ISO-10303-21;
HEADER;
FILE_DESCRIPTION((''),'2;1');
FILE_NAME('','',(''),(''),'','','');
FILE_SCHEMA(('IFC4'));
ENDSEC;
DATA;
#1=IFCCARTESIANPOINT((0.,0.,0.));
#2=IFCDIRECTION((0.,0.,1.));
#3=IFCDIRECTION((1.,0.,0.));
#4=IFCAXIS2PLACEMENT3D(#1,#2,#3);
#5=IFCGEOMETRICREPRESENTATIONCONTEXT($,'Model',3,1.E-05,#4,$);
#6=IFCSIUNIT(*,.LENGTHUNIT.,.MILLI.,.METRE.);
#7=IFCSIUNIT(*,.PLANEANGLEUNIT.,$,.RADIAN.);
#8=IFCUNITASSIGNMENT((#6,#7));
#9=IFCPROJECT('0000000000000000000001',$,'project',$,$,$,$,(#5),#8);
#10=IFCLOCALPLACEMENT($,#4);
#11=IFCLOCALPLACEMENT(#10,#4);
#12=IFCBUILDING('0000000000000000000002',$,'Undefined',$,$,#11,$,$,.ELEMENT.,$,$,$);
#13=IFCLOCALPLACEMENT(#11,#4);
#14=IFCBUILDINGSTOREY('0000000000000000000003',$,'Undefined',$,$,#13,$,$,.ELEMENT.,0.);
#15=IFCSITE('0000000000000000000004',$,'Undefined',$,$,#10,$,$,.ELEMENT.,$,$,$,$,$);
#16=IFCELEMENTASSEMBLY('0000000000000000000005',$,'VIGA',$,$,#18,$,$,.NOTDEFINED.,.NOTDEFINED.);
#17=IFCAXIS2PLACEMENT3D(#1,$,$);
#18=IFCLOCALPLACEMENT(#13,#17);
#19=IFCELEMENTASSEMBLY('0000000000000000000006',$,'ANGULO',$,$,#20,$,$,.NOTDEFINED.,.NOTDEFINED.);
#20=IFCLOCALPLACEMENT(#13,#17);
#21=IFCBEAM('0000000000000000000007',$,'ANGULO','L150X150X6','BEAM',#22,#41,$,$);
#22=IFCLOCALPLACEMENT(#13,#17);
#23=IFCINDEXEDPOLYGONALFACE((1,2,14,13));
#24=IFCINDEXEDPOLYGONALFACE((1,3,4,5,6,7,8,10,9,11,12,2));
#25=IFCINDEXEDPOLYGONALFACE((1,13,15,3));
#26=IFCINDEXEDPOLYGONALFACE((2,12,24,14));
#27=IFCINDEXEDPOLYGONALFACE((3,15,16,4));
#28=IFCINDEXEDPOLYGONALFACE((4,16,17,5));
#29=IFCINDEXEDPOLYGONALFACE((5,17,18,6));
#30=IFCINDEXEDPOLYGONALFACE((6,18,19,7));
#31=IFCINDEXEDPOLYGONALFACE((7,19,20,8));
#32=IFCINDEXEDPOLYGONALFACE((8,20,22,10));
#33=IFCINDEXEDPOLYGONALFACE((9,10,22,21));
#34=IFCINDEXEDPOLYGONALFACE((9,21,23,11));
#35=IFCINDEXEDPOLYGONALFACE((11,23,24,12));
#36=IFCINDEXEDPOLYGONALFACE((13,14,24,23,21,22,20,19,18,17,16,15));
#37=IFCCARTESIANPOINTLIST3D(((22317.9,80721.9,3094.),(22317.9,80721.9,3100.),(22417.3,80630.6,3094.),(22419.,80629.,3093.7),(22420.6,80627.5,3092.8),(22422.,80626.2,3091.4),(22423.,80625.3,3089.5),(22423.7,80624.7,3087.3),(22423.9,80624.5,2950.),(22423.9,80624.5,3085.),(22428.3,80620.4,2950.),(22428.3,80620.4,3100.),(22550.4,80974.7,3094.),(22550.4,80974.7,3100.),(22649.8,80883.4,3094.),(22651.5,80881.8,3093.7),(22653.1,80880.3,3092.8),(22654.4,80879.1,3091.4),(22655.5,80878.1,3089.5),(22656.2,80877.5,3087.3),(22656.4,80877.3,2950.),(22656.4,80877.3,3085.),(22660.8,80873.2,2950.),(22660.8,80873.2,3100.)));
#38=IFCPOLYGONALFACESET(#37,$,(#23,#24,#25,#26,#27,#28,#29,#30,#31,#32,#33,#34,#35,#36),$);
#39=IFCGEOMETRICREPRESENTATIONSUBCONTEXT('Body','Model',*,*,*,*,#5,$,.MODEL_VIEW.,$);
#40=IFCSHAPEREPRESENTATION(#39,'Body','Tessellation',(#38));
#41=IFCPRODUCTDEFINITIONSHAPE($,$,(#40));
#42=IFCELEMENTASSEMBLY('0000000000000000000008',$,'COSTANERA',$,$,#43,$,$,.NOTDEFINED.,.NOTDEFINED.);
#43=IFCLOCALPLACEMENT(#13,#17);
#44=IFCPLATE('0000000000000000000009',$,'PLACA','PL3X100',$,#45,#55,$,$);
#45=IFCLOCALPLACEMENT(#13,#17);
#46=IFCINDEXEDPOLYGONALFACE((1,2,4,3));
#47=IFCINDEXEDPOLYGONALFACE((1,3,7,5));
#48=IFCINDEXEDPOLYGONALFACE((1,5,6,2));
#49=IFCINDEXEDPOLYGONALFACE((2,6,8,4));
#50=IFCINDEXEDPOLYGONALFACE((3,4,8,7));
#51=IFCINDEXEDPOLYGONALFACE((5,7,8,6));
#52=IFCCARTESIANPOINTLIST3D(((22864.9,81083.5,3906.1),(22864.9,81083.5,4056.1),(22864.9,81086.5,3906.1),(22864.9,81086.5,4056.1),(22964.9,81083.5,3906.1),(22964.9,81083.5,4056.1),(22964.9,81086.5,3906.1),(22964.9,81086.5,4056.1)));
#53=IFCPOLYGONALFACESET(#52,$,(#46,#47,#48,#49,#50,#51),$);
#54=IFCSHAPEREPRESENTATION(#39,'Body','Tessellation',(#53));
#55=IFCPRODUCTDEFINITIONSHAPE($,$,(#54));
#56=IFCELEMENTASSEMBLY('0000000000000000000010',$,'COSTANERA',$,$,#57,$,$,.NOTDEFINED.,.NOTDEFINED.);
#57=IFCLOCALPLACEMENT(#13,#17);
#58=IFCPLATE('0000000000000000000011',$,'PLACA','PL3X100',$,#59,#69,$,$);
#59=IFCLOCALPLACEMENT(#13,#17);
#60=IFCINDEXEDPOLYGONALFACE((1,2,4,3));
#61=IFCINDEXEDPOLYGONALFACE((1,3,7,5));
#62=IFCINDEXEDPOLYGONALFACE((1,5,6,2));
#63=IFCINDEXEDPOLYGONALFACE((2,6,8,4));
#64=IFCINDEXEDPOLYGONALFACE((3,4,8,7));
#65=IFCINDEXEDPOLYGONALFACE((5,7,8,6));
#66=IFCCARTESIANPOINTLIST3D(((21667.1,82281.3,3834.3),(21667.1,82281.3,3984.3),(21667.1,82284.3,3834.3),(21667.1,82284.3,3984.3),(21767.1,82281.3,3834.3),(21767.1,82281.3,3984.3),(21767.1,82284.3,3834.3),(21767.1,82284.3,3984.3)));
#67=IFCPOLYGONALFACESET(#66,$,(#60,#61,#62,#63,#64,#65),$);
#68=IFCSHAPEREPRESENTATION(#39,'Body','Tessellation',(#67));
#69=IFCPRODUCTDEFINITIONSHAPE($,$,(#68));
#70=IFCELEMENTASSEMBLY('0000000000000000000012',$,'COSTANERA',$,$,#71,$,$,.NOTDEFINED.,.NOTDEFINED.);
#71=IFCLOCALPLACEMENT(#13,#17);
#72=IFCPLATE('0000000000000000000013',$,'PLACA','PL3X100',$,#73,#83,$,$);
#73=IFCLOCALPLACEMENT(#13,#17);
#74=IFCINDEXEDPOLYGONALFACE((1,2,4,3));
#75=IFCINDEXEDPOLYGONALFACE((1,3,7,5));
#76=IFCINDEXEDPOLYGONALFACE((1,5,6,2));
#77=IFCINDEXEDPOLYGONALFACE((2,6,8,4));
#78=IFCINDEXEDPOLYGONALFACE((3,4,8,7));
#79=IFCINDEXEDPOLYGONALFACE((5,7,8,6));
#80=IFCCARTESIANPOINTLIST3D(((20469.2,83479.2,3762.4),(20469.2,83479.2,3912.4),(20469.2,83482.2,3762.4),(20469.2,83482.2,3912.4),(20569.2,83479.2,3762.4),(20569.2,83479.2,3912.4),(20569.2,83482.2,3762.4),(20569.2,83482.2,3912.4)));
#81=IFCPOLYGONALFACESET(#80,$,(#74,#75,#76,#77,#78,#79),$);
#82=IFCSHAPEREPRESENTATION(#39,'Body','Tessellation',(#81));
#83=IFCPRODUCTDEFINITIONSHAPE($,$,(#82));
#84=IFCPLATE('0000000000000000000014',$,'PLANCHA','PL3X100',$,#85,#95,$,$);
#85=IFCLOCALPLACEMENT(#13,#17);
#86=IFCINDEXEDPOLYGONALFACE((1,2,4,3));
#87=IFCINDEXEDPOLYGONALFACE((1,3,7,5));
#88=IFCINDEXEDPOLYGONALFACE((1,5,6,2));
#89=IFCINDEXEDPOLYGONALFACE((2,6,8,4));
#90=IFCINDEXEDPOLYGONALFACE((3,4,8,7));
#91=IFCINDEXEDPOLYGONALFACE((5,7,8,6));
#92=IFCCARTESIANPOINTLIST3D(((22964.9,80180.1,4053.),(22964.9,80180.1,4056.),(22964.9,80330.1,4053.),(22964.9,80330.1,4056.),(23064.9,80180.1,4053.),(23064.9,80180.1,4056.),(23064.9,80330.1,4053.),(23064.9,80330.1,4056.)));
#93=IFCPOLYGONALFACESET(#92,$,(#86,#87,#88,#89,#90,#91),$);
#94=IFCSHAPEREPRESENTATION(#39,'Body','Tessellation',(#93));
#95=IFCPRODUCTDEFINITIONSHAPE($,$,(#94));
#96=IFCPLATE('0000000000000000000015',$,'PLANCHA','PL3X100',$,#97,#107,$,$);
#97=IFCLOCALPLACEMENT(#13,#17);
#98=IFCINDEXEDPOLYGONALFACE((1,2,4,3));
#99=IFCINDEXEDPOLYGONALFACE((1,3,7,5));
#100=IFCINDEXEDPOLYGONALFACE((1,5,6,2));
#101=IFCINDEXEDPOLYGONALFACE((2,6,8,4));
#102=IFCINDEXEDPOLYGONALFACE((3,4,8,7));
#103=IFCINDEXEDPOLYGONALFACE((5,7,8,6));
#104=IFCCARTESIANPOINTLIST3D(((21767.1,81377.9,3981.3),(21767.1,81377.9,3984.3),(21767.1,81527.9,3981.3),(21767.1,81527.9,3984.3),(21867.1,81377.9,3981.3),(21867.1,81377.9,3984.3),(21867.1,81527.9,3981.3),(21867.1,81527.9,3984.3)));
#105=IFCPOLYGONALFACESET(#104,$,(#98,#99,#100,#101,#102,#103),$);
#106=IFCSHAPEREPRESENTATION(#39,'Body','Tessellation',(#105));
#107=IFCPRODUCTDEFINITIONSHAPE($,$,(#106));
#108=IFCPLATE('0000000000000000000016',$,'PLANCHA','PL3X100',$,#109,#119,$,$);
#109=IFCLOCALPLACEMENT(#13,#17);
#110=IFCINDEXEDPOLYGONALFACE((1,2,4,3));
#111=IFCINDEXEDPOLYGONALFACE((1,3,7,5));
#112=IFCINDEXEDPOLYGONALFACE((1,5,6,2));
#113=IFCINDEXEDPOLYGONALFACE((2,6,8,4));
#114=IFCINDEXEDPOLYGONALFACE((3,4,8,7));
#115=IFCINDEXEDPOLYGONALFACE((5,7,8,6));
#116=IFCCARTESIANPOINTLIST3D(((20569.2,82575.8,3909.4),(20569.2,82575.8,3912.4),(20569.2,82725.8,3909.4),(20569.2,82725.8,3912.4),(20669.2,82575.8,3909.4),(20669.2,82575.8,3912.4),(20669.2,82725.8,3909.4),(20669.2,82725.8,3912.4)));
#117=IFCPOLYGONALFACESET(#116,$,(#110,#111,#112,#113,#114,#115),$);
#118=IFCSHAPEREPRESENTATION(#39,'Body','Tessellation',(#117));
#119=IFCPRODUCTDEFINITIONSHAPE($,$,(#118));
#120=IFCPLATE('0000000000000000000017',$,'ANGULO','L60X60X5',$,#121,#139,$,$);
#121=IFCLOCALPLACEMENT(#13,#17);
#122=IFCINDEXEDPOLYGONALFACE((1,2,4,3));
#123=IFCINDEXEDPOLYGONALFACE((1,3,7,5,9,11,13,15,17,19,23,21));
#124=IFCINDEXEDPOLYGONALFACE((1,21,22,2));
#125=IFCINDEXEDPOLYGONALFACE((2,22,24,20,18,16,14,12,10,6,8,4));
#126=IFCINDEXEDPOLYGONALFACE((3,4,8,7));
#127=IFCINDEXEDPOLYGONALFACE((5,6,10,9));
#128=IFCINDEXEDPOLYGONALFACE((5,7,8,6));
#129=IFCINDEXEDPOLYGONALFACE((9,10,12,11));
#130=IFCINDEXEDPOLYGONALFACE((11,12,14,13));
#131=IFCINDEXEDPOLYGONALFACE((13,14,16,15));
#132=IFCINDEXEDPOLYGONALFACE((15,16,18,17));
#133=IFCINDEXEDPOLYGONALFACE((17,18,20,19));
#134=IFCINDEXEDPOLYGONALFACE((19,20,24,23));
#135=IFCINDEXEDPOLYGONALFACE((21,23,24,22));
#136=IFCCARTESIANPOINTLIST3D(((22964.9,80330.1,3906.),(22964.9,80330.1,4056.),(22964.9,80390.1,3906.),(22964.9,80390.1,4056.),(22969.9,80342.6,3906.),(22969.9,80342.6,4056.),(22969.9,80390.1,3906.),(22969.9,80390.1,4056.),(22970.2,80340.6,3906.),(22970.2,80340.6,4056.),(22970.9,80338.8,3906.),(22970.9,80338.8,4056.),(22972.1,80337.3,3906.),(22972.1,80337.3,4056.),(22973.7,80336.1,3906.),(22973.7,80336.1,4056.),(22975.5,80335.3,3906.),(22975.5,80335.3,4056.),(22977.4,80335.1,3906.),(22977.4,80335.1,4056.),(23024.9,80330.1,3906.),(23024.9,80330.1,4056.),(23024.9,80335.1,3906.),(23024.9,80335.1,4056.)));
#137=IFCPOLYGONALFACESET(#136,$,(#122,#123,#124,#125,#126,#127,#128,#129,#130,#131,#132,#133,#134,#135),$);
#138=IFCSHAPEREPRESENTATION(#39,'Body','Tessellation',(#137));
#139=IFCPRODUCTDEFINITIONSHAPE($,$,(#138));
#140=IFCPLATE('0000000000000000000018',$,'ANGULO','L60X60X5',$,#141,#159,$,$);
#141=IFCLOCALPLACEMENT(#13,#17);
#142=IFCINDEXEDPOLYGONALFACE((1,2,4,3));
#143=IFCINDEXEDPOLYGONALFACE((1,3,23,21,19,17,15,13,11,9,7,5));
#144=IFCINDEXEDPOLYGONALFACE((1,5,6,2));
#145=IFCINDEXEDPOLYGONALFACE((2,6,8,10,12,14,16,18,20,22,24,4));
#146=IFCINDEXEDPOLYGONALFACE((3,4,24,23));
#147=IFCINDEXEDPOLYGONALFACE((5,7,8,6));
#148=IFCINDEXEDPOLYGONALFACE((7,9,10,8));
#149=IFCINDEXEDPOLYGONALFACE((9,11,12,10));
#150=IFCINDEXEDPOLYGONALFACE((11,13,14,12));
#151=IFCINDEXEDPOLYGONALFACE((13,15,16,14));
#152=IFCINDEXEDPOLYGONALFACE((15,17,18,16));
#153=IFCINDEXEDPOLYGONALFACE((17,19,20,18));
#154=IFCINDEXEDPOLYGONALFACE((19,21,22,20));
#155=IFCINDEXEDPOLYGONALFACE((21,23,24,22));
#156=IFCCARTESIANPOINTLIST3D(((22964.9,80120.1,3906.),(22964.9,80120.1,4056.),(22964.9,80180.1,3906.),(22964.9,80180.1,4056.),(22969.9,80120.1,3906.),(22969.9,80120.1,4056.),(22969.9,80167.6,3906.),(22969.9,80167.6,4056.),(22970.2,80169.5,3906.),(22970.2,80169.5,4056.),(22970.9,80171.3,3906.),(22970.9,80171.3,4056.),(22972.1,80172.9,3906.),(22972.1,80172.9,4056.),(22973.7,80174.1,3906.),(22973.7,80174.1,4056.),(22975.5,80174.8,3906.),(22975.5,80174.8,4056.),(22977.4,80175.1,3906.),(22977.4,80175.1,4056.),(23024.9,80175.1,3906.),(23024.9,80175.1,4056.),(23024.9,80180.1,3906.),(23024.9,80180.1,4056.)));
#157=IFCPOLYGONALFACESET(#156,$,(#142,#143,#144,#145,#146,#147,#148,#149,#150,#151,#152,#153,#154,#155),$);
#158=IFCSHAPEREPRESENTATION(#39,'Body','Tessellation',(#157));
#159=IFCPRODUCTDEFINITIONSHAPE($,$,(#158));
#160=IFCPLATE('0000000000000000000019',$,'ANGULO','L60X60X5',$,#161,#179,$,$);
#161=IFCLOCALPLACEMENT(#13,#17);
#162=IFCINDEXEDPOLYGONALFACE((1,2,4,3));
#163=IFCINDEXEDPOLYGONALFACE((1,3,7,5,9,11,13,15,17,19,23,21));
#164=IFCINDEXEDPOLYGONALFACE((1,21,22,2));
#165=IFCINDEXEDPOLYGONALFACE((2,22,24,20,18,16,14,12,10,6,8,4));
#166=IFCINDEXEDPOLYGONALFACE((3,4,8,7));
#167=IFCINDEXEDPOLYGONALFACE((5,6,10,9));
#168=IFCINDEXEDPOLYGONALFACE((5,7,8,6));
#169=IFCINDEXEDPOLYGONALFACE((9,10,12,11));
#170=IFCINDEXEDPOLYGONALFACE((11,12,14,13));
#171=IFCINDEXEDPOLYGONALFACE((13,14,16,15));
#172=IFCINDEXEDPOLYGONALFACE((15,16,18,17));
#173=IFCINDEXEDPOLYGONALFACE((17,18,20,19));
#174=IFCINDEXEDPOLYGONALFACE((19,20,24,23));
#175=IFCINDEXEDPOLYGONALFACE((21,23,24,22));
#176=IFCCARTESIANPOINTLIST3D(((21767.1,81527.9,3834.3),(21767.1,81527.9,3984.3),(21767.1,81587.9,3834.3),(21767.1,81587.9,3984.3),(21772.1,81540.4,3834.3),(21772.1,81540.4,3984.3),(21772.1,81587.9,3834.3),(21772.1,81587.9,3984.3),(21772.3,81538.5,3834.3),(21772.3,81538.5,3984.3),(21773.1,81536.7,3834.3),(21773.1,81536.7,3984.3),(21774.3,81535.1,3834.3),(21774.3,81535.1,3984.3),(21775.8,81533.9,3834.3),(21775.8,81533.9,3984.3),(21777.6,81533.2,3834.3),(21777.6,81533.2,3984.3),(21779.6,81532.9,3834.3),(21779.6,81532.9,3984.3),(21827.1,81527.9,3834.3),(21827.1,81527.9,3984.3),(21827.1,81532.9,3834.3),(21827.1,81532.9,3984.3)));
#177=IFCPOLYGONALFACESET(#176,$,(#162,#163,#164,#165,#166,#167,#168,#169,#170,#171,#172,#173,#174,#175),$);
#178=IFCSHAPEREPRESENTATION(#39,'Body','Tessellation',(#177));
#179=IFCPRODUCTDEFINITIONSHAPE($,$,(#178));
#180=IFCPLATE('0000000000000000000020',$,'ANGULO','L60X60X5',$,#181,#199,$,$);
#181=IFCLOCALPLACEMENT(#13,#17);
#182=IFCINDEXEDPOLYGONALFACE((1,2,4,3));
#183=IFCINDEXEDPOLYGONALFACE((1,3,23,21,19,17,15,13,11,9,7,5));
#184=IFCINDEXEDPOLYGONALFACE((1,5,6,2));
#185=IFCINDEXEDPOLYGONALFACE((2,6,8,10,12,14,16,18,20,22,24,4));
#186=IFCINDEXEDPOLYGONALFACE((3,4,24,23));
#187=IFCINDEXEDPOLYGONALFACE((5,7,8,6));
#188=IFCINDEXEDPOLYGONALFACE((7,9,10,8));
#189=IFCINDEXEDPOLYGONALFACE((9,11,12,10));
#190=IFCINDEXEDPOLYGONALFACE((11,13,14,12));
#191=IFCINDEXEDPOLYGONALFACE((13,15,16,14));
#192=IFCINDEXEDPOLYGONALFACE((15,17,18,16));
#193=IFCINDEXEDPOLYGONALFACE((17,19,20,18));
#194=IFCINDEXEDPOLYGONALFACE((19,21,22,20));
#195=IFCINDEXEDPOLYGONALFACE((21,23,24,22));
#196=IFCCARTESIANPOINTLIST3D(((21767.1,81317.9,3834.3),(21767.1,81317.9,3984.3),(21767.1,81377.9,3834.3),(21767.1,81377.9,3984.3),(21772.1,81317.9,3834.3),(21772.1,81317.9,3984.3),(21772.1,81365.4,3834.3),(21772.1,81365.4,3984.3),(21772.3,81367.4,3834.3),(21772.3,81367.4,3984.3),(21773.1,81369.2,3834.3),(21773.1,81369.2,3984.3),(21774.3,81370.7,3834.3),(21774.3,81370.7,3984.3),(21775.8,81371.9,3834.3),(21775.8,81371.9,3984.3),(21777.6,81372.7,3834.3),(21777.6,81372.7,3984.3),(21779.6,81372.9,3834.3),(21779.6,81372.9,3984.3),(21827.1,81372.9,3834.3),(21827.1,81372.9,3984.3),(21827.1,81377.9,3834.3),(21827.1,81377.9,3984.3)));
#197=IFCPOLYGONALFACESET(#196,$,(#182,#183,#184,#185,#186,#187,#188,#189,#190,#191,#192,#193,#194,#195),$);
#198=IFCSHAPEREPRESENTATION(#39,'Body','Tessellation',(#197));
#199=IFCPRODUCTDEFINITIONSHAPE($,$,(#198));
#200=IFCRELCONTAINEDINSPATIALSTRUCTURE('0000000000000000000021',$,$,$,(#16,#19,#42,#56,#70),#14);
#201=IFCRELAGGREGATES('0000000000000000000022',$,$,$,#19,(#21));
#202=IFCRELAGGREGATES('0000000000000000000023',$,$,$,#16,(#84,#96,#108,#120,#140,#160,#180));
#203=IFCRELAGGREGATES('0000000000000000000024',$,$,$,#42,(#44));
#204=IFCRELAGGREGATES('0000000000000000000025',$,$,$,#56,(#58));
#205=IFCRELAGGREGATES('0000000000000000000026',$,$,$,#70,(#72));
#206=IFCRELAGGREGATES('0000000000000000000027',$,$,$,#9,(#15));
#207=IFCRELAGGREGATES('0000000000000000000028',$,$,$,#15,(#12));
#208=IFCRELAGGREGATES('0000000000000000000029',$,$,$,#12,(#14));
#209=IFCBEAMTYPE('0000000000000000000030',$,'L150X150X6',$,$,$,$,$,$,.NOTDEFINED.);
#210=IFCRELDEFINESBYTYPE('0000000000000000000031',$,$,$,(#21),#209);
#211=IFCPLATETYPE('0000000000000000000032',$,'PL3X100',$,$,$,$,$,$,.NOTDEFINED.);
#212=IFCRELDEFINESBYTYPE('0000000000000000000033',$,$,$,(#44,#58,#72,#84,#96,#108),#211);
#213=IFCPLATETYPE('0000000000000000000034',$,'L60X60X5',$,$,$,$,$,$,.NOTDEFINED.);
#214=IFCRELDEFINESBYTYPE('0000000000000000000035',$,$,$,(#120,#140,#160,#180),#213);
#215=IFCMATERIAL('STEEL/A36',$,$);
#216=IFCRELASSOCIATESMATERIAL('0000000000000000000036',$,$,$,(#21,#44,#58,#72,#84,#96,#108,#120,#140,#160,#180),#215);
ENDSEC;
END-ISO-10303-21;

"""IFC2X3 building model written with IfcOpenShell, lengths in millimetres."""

from ifc_helpers import new_model, si_unit, frame, origin_with_axes, origin_2d_with_axis, place, context, subcontext, project, spatial, polyline, l_section, outline, extrude, material, type_object, element, aggregate, save


model = new_model("IFC2X3")

# Units and contexts
model_context = context("Model", 3, precision=1e-05, world=origin_with_axes())
body_context = subcontext(model_context, "Body", "Model", "MODEL_VIEW")
ifc_project = project(units=[si_unit("LENGTHUNIT", "METRE", prefix="MILLI"), si_unit("PLANEANGLEUNIT", "RADIAN")], contexts=[model_context])

# Site, building, storey
site_placement = place(None, origin_with_axes())
site = spatial("IfcSite", under=ifc_project, at=site_placement, Name="Undefined", CompositionType="ELEMENT")
building_placement = place(site_placement, origin_with_axes())
building = spatial("IfcBuilding", under=site, at=building_placement, Name="Undefined", CompositionType="ELEMENT")
storey_placement = place(building_placement, origin_with_axes())
storey = spatial("IfcBuildingStorey", under=building, at=storey_placement, Name="Undefined", CompositionType="ELEMENT", Elevation=0.0)

# Shared definitions
ifc_material_1 = material(Name="STEEL/A36")

# Element assembly
assembly_1_placement = place(storey_placement, origin_with_axes())
assembly_1 = element("IfcElementAssembly", 1, at=assembly_1_placement, inside=storey, Name="VIGA", AssemblyPlace="NOTDEFINED", PredefinedType="NOTDEFINED")

# Element assembly, beam
beam_type_1 = type_object("IfcBeamType", Name="L150X150X6", PredefinedType="NOTDEFINED")
assembly_2_placement = place(storey_placement, origin_with_axes())
assembly_2 = element("IfcElementAssembly", 2, at=assembly_2_placement, inside=storey, Name="ANGULO", AssemblyPlace="NOTDEFINED", PredefinedType="NOTDEFINED")
beam_1_placement = place(assembly_2_placement, frame((22605.6, 80924.0, 3025.0), z_axis=(-0.736087, 0.676887, 0.0), x_axis=(-0.676887, -0.736087, 0.0)))
beam_1 = element("IfcBeam", 3, at=beam_1_placement, type_object=beam_type_1, material=ifc_material_1, Name="ANGULO", Description="L150X150X6", ObjectType="BEAM", context=body_context, shape_type="SweptSolid", body=[
    extrude(l_section(Depth=150.0, Width=150.0, Thickness=6.0, FilletRadius=9.0, at=origin_2d_with_axis()), frame((343.4, 0.0, 0.0), z_axis=(-1.0, 0.0, 0.0), x_axis=(0.0, -1.0, 0.0)), (0.0, 0.0, 1.0), 343.4),
])
aggregate(assembly_2, [beam_1])

# Element assemblies, plates
assembly_3_placement = place(storey_placement, origin_with_axes())
assembly_3 = element("IfcElementAssembly", 4, at=assembly_3_placement, inside=storey, Name="COSTANERA", AssemblyPlace="NOTDEFINED", PredefinedType="NOTDEFINED")
plate_type_1 = type_object("IfcPlateType", Name="PL3X100", PredefinedType="NOTDEFINED")
plate_1_placement = place(assembly_3_placement, frame((22864.9, 81085.0, 3906.1), z_axis=(0.0, -1.0, 0.0), x_axis=(1.0, 0.0, 0.0)))
plate_1 = element("IfcPlate", 5, at=plate_1_placement, type_object=plate_type_1, material=ifc_material_1, Name="PLACA", Description="PL3X100", context=body_context, shape_type="SweptSolid", body=[
    extrude(outline(polyline([(0.0, 0.0), (100.0, 0.0), (100.0, 150.0), (0.0, 150.0), (0.0, 0.0)])), frame((0.0, 0.0, -1.5), z_axis=(0.0, 0.0, 1.0), x_axis=(1.0, 0.0, 0.0)), (0.0, 0.0, 1.0), 3.0),
])
assembly_4_placement = place(storey_placement, origin_with_axes())
assembly_4 = element("IfcElementAssembly", 6, at=assembly_4_placement, inside=storey, Name="COSTANERA", AssemblyPlace="NOTDEFINED", PredefinedType="NOTDEFINED")
plate_2_placement = place(assembly_4_placement, frame((21667.1, 82282.8, 3834.3), z_axis=(0.0, -1.0, 0.0), x_axis=(1.0, 0.0, 0.0)))
plate_2 = element("IfcPlate", 7, at=plate_2_placement, type_object=plate_type_1, material=ifc_material_1, Name="PLACA", Description="PL3X100", context=body_context, shape_type="SweptSolid", body=[
    extrude(outline(polyline([(0.0, 0.0), (100.0, 0.0), (100.0, 150.0), (0.0, 150.0), (0.0, 0.0)])), frame((0.0, 0.0, -1.5), z_axis=(0.0, 0.0, 1.0), x_axis=(1.0, 0.0, 0.0)), (0.0, 0.0, 1.0), 3.0),
])
assembly_5_placement = place(storey_placement, origin_with_axes())
assembly_5 = element("IfcElementAssembly", 8, at=assembly_5_placement, inside=storey, Name="COSTANERA", AssemblyPlace="NOTDEFINED", PredefinedType="NOTDEFINED")
plate_3_placement = place(assembly_5_placement, frame((20469.2, 83480.7, 3762.4), z_axis=(0.0, -1.0, 0.0), x_axis=(1.0, 0.0, 0.0)))
plate_3 = element("IfcPlate", 9, at=plate_3_placement, type_object=plate_type_1, material=ifc_material_1, Name="PLACA", Description="PL3X100", context=body_context, shape_type="SweptSolid", body=[
    extrude(outline(polyline([(0.0, 0.0), (100.0, 0.0), (100.0, 150.0), (0.0, 150.0), (0.0, 0.0)])), frame((0.0, 0.0, -1.5), z_axis=(0.0, 0.0, 1.0), x_axis=(1.0, 0.0, 0.0)), (0.0, 0.0, 1.0), 3.0),
])

# Plates
plate_4_placement = place(assembly_1_placement, frame((23064.9, 80180.1, 4054.5), z_axis=(0.0, 0.0, -1.0), x_axis=(-1.0, 0.0, 0.0)))
plate_4 = element("IfcPlate", 10, at=plate_4_placement, type_object=plate_type_1, material=ifc_material_1, Name="PLANCHA", Description="PL3X100", context=body_context, shape_type="SweptSolid", body=[
    extrude(outline(polyline([(0.0, 0.0), (100.0, 0.0), (100.0, 150.0), (0.0, 150.0), (0.0, 0.0)])), frame((0.0, 0.0, -1.5), z_axis=(0.0, 0.0, 1.0), x_axis=(1.0, 0.0, 0.0)), (0.0, 0.0, 1.0), 3.0),
])
plate_5_placement = place(assembly_1_placement, frame((21867.1, 81377.9, 3982.8), z_axis=(0.0, 0.0, -1.0), x_axis=(-1.0, 0.0, 0.0)))
plate_5 = element("IfcPlate", 11, at=plate_5_placement, type_object=plate_type_1, material=ifc_material_1, Name="PLANCHA", Description="PL3X100", context=body_context, shape_type="SweptSolid", body=[
    extrude(outline(polyline([(0.0, 0.0), (100.0, 0.0), (100.0, 150.0), (0.0, 150.0), (0.0, 0.0)])), frame((0.0, 0.0, -1.5), z_axis=(0.0, 0.0, 1.0), x_axis=(1.0, 0.0, 0.0)), (0.0, 0.0, 1.0), 3.0),
])
plate_6_placement = place(assembly_1_placement, frame((20669.2, 82575.8, 3910.9), z_axis=(0.0, 0.0, -1.0), x_axis=(-1.0, 0.0, 0.0)))
plate_6 = element("IfcPlate", 12, at=plate_6_placement, type_object=plate_type_1, material=ifc_material_1, Name="PLANCHA", Description="PL3X100", context=body_context, shape_type="SweptSolid", body=[
    extrude(outline(polyline([(0.0, 0.0), (100.0, 0.0), (100.0, 150.0), (0.0, 150.0), (0.0, 0.0)])), frame((0.0, 0.0, -1.5), z_axis=(0.0, 0.0, 1.0), x_axis=(1.0, 0.0, 0.0)), (0.0, 0.0, 1.0), 3.0),
])
plate_type_2 = type_object("IfcPlateType", Name="L60X60X5", PredefinedType="NOTDEFINED")
plate_7_placement = place(assembly_1_placement, frame((22994.9, 80360.1, 3906.0), z_axis=(1.0, 0.0, 0.0), x_axis=(0.0, 0.0, 1.0)))
plate_7 = element("IfcPlate", 13, at=plate_7_placement, type_object=plate_type_2, material=ifc_material_1, Name="ANGULO", Description="L60X60X5", context=body_context, shape_type="SweptSolid", body=[
    extrude(l_section(Depth=60.0, Width=60.0, Thickness=5.0, FilletRadius=7.5, at=origin_2d_with_axis()), frame((150.0, 0.0, 0.0), z_axis=(-1.0, 0.0, 0.0), x_axis=(0.0, -1.0, 0.0)), (0.0, 0.0, 1.0), 150.0),
])
plate_8_placement = place(assembly_1_placement, frame((22994.9, 80150.1, 4056.0), z_axis=(1.0, 0.0, 0.0), x_axis=(0.0, 0.0, -1.0)))
plate_8 = element("IfcPlate", 14, at=plate_8_placement, type_object=plate_type_2, material=ifc_material_1, Name="ANGULO", Description="L60X60X5", context=body_context, shape_type="SweptSolid", body=[
    extrude(l_section(Depth=60.0, Width=60.0, Thickness=5.0, FilletRadius=7.5, at=origin_2d_with_axis()), frame((150.0, 0.0, 0.0), z_axis=(-1.0, 0.0, 0.0), x_axis=(0.0, -1.0, 0.0)), (0.0, 0.0, 1.0), 150.0),
])
plate_9_placement = place(assembly_1_placement, frame((21797.1, 81557.9, 3834.3), z_axis=(1.0, 0.0, 0.0), x_axis=(0.0, 0.0, 1.0)))
plate_9 = element("IfcPlate", 15, at=plate_9_placement, type_object=plate_type_2, material=ifc_material_1, Name="ANGULO", Description="L60X60X5", context=body_context, shape_type="SweptSolid", body=[
    extrude(l_section(Depth=60.0, Width=60.0, Thickness=5.0, FilletRadius=7.5, at=origin_2d_with_axis()), frame((150.0, 0.0, 0.0), z_axis=(-1.0, 0.0, 0.0), x_axis=(0.0, -1.0, 0.0)), (0.0, 0.0, 1.0), 150.0),
])
plate_10_placement = place(assembly_1_placement, frame((21797.1, 81347.9, 3984.3), z_axis=(1.0, 0.0, 0.0), x_axis=(0.0, 0.0, -1.0)))
plate_10 = element("IfcPlate", 16, at=plate_10_placement, type_object=plate_type_2, material=ifc_material_1, Name="ANGULO", Description="L60X60X5", context=body_context, shape_type="SweptSolid", body=[
    extrude(l_section(Depth=60.0, Width=60.0, Thickness=5.0, FilletRadius=7.5, at=origin_2d_with_axis()), frame((150.0, 0.0, 0.0), z_axis=(-1.0, 0.0, 0.0), x_axis=(0.0, -1.0, 0.0)), (0.0, 0.0, 1.0), 150.0),
])
aggregate(assembly_1, [plate_4, plate_5, plate_6, plate_7, plate_8, plate_9, plate_10])

aggregate(assembly_3, [plate_1])
aggregate(assembly_4, [plate_2])
aggregate(assembly_5, [plate_3])

save(model, "model.ifc")
